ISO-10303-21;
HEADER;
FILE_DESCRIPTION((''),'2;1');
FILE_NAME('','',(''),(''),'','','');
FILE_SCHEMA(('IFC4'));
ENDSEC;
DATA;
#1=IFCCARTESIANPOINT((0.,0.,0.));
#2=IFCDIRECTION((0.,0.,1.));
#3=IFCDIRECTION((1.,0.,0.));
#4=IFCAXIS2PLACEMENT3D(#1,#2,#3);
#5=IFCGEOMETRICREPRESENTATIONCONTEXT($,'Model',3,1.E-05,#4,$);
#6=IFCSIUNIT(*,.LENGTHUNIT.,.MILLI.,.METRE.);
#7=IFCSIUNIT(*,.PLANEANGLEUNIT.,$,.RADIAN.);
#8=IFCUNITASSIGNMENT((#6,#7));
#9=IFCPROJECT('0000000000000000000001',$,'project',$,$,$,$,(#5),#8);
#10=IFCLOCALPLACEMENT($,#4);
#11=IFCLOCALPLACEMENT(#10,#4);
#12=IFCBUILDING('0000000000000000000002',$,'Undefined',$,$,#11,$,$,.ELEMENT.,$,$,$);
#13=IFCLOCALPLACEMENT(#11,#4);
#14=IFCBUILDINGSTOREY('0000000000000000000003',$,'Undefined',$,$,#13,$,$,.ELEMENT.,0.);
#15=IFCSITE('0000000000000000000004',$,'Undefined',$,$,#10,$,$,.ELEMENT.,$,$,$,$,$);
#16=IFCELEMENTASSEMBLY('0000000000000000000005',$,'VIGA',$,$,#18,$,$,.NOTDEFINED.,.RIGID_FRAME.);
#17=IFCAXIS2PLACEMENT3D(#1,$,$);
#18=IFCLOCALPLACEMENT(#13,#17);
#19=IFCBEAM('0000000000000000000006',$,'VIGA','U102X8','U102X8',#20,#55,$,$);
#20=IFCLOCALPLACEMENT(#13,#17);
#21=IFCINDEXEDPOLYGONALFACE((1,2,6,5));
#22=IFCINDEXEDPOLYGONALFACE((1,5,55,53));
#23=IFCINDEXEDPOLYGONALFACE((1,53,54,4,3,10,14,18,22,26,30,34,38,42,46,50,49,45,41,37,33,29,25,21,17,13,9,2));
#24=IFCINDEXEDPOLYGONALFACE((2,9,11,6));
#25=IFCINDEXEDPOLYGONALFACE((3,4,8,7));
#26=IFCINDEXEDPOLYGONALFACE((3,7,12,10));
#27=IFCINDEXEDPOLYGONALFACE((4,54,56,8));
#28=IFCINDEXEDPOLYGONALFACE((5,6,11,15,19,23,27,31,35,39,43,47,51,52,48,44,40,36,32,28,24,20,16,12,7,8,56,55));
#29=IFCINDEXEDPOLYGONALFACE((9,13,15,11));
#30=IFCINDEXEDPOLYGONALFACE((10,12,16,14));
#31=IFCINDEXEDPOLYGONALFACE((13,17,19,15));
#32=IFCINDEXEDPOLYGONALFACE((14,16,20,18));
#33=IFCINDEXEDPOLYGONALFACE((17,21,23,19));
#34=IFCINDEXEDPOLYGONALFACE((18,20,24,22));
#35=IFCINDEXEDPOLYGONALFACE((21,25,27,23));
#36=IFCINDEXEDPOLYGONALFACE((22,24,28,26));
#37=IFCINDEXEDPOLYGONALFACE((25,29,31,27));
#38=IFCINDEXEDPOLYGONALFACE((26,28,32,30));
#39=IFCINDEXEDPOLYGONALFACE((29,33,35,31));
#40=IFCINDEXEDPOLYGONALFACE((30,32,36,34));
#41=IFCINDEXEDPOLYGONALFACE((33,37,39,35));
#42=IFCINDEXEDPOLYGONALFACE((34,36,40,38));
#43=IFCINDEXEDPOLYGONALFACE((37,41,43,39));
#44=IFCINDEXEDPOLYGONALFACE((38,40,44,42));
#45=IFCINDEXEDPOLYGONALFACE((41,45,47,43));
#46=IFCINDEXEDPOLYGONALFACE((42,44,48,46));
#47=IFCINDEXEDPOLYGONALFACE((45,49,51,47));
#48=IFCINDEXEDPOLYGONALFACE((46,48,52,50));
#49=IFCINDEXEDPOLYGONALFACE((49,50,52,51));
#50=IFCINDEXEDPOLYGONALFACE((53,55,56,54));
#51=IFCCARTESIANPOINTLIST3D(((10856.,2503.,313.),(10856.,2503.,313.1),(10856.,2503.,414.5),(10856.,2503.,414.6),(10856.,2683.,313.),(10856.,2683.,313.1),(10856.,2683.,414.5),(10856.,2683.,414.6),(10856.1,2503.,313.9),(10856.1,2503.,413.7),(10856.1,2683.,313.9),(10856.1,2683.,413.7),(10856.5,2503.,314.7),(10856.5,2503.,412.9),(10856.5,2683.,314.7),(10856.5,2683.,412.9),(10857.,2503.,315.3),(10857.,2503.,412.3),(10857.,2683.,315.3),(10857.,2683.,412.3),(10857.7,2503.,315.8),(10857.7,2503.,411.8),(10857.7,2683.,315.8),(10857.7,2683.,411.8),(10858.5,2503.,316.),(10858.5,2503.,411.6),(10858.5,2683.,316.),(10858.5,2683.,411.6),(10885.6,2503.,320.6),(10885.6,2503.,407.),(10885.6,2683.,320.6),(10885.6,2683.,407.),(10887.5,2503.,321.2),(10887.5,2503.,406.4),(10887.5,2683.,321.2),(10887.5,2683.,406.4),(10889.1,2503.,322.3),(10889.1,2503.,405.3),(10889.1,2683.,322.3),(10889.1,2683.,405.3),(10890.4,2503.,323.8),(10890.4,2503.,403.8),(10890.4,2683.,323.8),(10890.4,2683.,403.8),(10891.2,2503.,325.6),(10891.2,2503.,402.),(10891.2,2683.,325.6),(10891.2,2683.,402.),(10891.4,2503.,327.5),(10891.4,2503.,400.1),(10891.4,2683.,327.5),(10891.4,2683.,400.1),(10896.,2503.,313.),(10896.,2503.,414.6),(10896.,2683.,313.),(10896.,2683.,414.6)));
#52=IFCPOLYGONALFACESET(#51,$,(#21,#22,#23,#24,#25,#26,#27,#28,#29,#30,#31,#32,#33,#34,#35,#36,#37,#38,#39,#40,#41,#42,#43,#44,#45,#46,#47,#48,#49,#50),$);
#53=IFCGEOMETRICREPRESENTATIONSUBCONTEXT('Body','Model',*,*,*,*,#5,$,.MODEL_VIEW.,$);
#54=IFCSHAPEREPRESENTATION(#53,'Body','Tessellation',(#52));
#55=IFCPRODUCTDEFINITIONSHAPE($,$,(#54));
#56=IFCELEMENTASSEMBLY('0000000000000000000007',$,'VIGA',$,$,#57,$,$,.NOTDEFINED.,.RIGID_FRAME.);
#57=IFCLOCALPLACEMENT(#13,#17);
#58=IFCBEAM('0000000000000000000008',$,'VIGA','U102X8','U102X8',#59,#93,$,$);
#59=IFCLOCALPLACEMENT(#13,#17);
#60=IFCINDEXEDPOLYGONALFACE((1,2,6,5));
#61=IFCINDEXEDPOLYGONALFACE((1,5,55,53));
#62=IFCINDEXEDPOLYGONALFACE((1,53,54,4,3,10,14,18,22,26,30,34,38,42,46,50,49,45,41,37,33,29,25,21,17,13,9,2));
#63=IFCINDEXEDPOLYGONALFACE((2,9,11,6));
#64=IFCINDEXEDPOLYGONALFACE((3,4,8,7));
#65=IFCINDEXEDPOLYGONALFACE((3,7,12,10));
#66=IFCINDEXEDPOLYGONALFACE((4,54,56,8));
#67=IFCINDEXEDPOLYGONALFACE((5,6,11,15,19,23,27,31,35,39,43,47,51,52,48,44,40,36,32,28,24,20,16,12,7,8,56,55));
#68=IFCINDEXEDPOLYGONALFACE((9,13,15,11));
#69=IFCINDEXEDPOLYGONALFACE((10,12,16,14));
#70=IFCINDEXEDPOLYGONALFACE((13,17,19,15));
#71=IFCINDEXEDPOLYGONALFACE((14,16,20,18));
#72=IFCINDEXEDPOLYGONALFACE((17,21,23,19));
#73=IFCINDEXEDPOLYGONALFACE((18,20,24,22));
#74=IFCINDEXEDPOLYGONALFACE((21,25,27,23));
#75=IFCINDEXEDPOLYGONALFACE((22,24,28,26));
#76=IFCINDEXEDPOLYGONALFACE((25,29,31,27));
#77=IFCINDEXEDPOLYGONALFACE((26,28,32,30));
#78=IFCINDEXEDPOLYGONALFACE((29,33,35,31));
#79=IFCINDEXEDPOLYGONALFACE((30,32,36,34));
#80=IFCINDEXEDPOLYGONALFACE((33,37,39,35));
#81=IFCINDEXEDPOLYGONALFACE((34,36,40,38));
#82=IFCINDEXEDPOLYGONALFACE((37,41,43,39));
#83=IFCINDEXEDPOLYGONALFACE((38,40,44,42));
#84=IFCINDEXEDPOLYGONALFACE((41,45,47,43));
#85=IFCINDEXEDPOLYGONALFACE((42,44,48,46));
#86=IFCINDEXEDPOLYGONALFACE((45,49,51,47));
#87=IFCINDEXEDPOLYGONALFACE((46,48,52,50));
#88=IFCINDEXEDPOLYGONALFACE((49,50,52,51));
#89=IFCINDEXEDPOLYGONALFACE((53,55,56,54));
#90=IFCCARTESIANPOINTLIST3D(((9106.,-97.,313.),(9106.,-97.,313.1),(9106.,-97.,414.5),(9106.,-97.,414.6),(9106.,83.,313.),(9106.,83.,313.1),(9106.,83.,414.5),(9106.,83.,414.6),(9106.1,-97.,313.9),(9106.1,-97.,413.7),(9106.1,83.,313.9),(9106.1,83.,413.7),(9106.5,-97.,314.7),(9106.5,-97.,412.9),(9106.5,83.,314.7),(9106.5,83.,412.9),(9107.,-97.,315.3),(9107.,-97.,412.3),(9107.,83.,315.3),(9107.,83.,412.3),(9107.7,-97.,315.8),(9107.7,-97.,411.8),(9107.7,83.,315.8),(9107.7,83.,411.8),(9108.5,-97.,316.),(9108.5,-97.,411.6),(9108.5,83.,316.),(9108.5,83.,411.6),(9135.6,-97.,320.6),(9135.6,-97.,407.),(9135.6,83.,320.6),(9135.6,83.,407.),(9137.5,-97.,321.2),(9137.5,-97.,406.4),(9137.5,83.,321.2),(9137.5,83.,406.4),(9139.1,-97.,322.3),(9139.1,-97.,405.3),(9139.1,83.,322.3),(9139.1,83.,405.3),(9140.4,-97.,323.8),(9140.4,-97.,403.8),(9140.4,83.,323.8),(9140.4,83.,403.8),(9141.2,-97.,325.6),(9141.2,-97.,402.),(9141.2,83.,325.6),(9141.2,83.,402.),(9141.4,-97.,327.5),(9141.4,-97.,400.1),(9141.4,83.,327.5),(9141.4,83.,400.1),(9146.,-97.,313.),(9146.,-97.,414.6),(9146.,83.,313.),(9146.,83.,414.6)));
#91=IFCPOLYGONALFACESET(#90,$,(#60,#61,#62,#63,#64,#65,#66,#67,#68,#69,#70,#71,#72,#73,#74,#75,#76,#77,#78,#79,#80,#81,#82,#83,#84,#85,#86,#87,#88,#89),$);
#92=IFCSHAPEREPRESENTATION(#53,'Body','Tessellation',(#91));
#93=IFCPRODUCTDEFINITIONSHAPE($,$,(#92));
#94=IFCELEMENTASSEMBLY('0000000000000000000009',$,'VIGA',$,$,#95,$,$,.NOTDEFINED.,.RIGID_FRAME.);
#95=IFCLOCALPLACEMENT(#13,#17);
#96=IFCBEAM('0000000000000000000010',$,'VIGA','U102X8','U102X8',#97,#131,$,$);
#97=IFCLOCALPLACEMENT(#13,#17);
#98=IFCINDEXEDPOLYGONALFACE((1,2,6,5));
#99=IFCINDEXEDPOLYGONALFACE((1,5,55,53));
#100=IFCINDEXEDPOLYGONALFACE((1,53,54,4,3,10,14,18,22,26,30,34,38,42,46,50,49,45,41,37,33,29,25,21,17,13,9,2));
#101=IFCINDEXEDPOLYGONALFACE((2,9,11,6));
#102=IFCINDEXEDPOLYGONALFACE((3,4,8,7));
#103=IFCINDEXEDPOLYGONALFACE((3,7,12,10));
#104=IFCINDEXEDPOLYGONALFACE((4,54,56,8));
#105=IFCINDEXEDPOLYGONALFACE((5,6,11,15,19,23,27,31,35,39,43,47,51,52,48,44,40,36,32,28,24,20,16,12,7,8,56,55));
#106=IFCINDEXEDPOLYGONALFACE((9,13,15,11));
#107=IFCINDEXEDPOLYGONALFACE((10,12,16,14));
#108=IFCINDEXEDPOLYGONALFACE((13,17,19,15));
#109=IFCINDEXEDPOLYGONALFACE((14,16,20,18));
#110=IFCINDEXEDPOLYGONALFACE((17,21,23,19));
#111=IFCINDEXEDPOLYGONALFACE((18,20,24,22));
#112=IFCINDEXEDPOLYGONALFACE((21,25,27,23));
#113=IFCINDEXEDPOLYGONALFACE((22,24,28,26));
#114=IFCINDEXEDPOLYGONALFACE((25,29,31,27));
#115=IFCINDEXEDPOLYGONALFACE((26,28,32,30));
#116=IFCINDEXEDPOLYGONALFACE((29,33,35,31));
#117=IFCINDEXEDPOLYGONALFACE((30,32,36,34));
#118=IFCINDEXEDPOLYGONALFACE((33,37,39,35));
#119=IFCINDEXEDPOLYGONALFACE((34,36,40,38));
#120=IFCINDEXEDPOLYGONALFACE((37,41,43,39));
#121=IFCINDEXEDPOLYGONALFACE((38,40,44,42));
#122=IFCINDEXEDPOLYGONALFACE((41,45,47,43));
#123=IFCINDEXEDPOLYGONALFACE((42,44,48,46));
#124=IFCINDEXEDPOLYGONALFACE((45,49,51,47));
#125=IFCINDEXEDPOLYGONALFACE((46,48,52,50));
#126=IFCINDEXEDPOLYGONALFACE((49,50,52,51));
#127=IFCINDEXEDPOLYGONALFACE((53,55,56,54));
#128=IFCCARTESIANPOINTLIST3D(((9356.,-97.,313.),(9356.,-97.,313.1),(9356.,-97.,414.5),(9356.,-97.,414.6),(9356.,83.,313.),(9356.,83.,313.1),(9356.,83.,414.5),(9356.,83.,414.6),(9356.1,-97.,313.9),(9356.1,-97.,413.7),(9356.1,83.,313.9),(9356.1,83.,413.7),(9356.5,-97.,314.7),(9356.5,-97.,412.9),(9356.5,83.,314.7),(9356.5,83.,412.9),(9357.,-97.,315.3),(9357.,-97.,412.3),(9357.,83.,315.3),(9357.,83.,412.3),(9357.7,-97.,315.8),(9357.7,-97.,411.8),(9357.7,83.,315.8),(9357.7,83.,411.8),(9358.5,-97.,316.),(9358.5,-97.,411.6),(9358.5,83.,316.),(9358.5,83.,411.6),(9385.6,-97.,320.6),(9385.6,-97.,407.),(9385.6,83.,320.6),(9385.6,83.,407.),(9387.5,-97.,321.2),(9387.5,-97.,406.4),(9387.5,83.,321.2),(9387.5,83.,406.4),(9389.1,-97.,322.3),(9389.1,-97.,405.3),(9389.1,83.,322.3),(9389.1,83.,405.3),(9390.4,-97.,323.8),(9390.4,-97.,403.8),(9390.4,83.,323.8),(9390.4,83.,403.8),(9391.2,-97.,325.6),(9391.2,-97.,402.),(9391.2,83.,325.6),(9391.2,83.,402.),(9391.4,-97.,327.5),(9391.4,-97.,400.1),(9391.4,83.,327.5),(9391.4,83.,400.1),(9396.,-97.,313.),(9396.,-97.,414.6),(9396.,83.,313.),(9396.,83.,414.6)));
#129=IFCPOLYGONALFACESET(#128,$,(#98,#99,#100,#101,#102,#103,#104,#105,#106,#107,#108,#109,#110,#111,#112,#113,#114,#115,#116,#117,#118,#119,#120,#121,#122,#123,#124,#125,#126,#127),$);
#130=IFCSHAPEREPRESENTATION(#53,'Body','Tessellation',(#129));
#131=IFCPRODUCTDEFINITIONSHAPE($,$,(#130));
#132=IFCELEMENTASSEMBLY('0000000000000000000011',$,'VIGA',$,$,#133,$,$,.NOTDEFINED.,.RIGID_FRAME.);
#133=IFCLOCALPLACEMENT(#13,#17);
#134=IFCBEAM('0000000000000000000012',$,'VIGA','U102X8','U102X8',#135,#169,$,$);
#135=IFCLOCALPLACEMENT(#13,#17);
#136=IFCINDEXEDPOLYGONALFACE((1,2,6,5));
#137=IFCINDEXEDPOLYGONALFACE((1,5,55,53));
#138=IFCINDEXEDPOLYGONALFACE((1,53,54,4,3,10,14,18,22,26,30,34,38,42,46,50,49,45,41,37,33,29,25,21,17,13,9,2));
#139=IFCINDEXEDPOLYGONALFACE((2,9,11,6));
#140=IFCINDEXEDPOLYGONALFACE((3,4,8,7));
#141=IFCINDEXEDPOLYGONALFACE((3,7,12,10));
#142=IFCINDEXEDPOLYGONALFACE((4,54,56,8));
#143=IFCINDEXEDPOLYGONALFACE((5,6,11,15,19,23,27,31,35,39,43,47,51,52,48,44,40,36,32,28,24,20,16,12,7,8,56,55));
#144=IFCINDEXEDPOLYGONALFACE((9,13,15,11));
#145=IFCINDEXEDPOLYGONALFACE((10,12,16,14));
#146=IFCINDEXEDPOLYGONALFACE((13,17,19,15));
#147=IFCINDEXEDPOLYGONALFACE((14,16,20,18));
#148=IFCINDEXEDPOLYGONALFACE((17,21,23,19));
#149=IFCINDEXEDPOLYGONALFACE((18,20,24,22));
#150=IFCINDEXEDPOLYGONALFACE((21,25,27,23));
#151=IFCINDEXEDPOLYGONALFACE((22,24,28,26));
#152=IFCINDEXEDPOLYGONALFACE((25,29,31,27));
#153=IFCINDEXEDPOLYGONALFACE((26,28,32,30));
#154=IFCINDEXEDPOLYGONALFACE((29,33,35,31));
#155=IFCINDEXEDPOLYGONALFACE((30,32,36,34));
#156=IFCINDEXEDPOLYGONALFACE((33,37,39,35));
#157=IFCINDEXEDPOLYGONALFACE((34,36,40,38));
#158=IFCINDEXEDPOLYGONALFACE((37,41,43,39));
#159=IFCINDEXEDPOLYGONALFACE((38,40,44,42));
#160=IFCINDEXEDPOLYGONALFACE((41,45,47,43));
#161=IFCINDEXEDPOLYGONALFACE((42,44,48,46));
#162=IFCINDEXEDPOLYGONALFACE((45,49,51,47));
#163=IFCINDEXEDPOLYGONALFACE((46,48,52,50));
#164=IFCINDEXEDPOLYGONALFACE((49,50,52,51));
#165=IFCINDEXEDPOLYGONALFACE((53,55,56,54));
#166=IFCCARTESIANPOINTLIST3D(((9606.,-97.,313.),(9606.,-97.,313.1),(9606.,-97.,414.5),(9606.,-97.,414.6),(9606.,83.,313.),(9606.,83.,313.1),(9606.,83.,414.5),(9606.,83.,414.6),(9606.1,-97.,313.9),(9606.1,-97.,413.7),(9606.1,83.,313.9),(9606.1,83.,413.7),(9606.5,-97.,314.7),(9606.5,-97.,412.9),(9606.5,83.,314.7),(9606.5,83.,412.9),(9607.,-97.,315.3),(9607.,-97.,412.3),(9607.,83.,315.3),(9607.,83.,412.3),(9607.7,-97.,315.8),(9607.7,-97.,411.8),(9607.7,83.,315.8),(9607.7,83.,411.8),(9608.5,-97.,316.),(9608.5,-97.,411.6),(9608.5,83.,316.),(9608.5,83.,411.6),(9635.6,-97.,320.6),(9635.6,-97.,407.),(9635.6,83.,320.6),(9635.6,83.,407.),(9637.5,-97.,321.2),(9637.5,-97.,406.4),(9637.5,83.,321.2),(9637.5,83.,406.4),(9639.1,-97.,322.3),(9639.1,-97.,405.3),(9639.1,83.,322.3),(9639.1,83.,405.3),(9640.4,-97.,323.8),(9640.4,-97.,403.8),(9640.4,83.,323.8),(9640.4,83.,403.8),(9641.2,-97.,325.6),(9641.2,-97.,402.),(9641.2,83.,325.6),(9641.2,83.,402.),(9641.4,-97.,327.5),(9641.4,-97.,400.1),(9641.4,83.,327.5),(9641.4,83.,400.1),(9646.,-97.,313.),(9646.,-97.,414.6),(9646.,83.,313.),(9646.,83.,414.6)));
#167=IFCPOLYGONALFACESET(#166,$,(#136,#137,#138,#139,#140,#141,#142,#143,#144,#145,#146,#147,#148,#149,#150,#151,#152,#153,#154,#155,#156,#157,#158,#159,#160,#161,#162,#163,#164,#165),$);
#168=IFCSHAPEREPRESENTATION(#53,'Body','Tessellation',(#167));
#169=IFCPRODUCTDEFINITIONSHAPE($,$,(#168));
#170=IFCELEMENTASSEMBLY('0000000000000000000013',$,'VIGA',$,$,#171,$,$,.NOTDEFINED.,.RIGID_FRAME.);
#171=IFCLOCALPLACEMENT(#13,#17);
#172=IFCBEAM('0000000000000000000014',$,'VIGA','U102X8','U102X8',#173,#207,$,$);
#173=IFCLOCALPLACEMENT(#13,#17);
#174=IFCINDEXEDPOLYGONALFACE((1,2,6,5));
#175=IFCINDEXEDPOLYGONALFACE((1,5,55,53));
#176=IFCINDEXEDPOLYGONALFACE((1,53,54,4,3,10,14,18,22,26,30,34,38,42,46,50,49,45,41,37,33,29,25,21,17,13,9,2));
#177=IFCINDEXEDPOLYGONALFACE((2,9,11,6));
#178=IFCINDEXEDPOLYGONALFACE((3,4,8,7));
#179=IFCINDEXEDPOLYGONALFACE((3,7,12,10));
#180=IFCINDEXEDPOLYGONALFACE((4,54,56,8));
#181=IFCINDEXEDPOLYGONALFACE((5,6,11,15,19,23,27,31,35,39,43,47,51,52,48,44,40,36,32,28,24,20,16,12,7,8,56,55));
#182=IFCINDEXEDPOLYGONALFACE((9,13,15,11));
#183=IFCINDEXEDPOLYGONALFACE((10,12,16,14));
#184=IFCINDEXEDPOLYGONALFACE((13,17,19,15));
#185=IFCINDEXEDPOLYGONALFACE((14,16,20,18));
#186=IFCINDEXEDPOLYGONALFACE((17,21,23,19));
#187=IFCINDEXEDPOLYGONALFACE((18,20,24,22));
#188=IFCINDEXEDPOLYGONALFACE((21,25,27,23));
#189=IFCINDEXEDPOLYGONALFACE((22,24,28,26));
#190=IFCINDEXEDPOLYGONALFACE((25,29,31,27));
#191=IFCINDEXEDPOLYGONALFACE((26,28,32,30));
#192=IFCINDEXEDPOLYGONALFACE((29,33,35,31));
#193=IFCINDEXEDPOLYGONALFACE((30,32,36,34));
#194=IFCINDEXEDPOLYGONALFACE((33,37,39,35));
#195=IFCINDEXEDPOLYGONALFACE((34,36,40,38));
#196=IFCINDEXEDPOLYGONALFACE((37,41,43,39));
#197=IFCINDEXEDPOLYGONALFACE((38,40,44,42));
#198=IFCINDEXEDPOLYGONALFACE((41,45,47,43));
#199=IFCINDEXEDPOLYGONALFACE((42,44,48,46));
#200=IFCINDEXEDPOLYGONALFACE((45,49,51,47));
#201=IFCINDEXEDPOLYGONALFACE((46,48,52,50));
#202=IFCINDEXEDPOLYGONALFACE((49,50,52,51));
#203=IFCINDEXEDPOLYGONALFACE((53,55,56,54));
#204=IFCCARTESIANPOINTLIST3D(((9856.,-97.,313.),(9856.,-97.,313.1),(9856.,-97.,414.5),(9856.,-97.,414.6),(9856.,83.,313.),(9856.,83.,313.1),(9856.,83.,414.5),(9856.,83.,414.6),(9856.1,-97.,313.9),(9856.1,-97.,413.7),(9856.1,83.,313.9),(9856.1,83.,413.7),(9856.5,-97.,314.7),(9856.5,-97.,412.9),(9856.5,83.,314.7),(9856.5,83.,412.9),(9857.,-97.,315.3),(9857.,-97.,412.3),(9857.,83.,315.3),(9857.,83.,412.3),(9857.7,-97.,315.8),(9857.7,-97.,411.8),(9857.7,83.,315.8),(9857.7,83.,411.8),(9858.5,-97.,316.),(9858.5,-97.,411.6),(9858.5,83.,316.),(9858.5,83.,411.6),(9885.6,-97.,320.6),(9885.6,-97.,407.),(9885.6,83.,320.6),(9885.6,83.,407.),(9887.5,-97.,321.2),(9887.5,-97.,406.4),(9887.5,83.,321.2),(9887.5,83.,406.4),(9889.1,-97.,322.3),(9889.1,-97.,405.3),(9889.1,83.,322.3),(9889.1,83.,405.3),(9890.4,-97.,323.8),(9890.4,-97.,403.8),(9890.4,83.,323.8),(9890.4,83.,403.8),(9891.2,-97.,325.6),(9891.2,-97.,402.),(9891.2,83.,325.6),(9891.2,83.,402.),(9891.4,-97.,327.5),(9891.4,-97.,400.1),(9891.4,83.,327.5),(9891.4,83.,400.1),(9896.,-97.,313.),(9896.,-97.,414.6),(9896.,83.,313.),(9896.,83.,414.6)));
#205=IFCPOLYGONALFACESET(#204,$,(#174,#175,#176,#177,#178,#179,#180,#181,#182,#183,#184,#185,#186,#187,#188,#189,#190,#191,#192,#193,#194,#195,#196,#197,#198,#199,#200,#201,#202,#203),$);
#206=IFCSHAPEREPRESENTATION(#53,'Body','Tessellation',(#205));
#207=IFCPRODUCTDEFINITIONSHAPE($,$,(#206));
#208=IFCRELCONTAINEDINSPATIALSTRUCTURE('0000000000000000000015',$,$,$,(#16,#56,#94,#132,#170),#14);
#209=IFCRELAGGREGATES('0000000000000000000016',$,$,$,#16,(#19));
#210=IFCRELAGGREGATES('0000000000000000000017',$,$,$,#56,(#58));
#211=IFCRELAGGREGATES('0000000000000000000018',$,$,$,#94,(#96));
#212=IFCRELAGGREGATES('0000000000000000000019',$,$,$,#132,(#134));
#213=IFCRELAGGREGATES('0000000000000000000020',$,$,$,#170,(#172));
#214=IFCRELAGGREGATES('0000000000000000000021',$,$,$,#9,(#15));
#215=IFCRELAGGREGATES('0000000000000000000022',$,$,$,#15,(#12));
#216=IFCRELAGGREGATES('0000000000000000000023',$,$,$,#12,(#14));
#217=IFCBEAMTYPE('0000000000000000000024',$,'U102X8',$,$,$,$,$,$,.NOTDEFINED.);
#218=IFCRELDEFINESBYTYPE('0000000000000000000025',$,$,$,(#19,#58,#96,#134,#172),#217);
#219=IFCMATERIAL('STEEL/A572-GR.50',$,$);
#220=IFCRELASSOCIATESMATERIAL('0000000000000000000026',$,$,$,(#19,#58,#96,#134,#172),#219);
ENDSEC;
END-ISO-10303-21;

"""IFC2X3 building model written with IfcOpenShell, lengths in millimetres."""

from ifc_helpers import new_model, si_unit, frame, origin_with_axes, origin_2d_with_axis, place, context, subcontext, project, spatial, u_section, extrude, material, type_object, element, aggregate, save


model = new_model("IFC2X3")

# Units and contexts
model_context = context("Model", 3, precision=1e-05, world=origin_with_axes())
body_context = subcontext(model_context, "Body", "Model", "MODEL_VIEW")
ifc_project = project(units=[si_unit("LENGTHUNIT", "METRE", prefix="MILLI"), si_unit("PLANEANGLEUNIT", "RADIAN")], contexts=[model_context])

# Site, building, storey
site_placement = place(None, origin_with_axes())
site = spatial("IfcSite", under=ifc_project, at=site_placement, Name="Undefined", CompositionType="ELEMENT")
building_placement = place(site_placement, origin_with_axes())
building = spatial("IfcBuilding", under=site, at=building_placement, Name="Undefined", CompositionType="ELEMENT")
storey_placement = place(building_placement, origin_with_axes())
storey = spatial("IfcBuildingStorey", under=building, at=storey_placement, Name="Undefined", CompositionType="ELEMENT", Elevation=0.0)

# Element assemblies, beams
ifc_material_1 = material(Name="STEEL/A572-GR.50")
beam_type = type_object("IfcBeamType", Name="U102X8", PredefinedType="NOTDEFINED")
assembly_1_placement = place(storey_placement, origin_with_axes())
assembly_1 = element("IfcElementAssembly", 1, at=assembly_1_placement, inside=storey, Name="VIGA", AssemblyPlace="NOTDEFINED", PredefinedType="RIGID_FRAME")
beam_1_placement = place(assembly_1_placement, frame((10876.0, 2683.0, 363.8), z_axis=(0.0, 0.0, 1.0), x_axis=(0.0, -1.0, 0.0)))
beam_1 = element("IfcBeam", 2, at=beam_1_placement, type_object=beam_type, material=ifc_material_1, Name="VIGA", Description="U102X8", ObjectType="U102X8", context=body_context, shape_type="SweptSolid", body=[
    extrude(u_section(Depth=101.6, FlangeWidth=40.0, WebThickness=4.6, FlangeThickness=6.0, FilletRadius=7.0, EdgeRadius=3.0, FlangeSlope=0.16839, at=origin_2d_with_axis()), frame((180.0, 0.0, 0.0), z_axis=(-1.0, 0.0, 0.0), x_axis=(0.0, -1.0, 0.0)), (0.0, 0.0, 1.0), 180.0),
])
aggregate(assembly_1, [beam_1])
assembly_2_placement = place(storey_placement, origin_with_axes())
assembly_2 = element("IfcElementAssembly", 3, at=assembly_2_placement, inside=storey, Name="VIGA", AssemblyPlace="NOTDEFINED", PredefinedType="RIGID_FRAME")
beam_2_placement = place(assembly_2_placement, frame((9126.0, 83.0, 363.8), z_axis=(0.0, 0.0, 1.0), x_axis=(0.0, -1.0, 0.0)))
beam_2 = element("IfcBeam", 4, at=beam_2_placement, type_object=beam_type, material=ifc_material_1, Name="VIGA", Description="U102X8", ObjectType="U102X8", context=body_context, shape_type="SweptSolid", body=[
    extrude(u_section(Depth=101.6, FlangeWidth=40.0, WebThickness=4.6, FlangeThickness=6.0, FilletRadius=7.0, EdgeRadius=3.0, FlangeSlope=0.16839, at=origin_2d_with_axis()), frame((180.0, 0.0, 0.0), z_axis=(-1.0, 0.0, 0.0), x_axis=(0.0, -1.0, 0.0)), (0.0, 0.0, 1.0), 180.0),
])
aggregate(assembly_2, [beam_2])
assembly_3_placement = place(storey_placement, origin_with_axes())
assembly_3 = element("IfcElementAssembly", 5, at=assembly_3_placement, inside=storey, Name="VIGA", AssemblyPlace="NOTDEFINED", PredefinedType="RIGID_FRAME")
beam_3_placement = place(assembly_3_placement, frame((9376.0, 83.0, 363.8), z_axis=(0.0, 0.0, 1.0), x_axis=(0.0, -1.0, 0.0)))
beam_3 = element("IfcBeam", 6, at=beam_3_placement, type_object=beam_type, material=ifc_material_1, Name="VIGA", Description="U102X8", ObjectType="U102X8", context=body_context, shape_type="SweptSolid", body=[
    extrude(u_section(Depth=101.6, FlangeWidth=40.0, WebThickness=4.6, FlangeThickness=6.0, FilletRadius=7.0, EdgeRadius=3.0, FlangeSlope=0.16839, at=origin_2d_with_axis()), frame((180.0, 0.0, 0.0), z_axis=(-1.0, 0.0, 0.0), x_axis=(0.0, -1.0, 0.0)), (0.0, 0.0, 1.0), 180.0),
])
aggregate(assembly_3, [beam_3])
assembly_4_placement = place(storey_placement, origin_with_axes())
assembly_4 = element("IfcElementAssembly", 7, at=assembly_4_placement, inside=storey, Name="VIGA", AssemblyPlace="NOTDEFINED", PredefinedType="RIGID_FRAME")
beam_4_placement = place(assembly_4_placement, frame((9626.0, 83.0, 363.8), z_axis=(0.0, 0.0, 1.0), x_axis=(0.0, -1.0, 0.0)))
beam_4 = element("IfcBeam", 8, at=beam_4_placement, type_object=beam_type, material=ifc_material_1, Name="VIGA", Description="U102X8", ObjectType="U102X8", context=body_context, shape_type="SweptSolid", body=[
    extrude(u_section(Depth=101.6, FlangeWidth=40.0, WebThickness=4.6, FlangeThickness=6.0, FilletRadius=7.0, EdgeRadius=3.0, FlangeSlope=0.16839, at=origin_2d_with_axis()), frame((180.0, 0.0, 0.0), z_axis=(-1.0, 0.0, 0.0), x_axis=(0.0, -1.0, 0.0)), (0.0, 0.0, 1.0), 180.0),
])
aggregate(assembly_4, [beam_4])
assembly_5_placement = place(storey_placement, origin_with_axes())
assembly_5 = element("IfcElementAssembly", 9, at=assembly_5_placement, inside=storey, Name="VIGA", AssemblyPlace="NOTDEFINED", PredefinedType="RIGID_FRAME")
beam_5_placement = place(assembly_5_placement, frame((9876.0, 83.0, 363.8), z_axis=(0.0, 0.0, 1.0), x_axis=(0.0, -1.0, 0.0)))
beam_5 = element("IfcBeam", 10, at=beam_5_placement, type_object=beam_type, material=ifc_material_1, Name="VIGA", Description="U102X8", ObjectType="U102X8", context=body_context, shape_type="SweptSolid", body=[
    extrude(u_section(Depth=101.6, FlangeWidth=40.0, WebThickness=4.6, FlangeThickness=6.0, FilletRadius=7.0, EdgeRadius=3.0, FlangeSlope=0.16839, at=origin_2d_with_axis()), frame((180.0, 0.0, 0.0), z_axis=(-1.0, 0.0, 0.0), x_axis=(0.0, -1.0, 0.0)), (0.0, 0.0, 1.0), 180.0),
])
aggregate(assembly_5, [beam_5])

save(model, "model.ifc")
